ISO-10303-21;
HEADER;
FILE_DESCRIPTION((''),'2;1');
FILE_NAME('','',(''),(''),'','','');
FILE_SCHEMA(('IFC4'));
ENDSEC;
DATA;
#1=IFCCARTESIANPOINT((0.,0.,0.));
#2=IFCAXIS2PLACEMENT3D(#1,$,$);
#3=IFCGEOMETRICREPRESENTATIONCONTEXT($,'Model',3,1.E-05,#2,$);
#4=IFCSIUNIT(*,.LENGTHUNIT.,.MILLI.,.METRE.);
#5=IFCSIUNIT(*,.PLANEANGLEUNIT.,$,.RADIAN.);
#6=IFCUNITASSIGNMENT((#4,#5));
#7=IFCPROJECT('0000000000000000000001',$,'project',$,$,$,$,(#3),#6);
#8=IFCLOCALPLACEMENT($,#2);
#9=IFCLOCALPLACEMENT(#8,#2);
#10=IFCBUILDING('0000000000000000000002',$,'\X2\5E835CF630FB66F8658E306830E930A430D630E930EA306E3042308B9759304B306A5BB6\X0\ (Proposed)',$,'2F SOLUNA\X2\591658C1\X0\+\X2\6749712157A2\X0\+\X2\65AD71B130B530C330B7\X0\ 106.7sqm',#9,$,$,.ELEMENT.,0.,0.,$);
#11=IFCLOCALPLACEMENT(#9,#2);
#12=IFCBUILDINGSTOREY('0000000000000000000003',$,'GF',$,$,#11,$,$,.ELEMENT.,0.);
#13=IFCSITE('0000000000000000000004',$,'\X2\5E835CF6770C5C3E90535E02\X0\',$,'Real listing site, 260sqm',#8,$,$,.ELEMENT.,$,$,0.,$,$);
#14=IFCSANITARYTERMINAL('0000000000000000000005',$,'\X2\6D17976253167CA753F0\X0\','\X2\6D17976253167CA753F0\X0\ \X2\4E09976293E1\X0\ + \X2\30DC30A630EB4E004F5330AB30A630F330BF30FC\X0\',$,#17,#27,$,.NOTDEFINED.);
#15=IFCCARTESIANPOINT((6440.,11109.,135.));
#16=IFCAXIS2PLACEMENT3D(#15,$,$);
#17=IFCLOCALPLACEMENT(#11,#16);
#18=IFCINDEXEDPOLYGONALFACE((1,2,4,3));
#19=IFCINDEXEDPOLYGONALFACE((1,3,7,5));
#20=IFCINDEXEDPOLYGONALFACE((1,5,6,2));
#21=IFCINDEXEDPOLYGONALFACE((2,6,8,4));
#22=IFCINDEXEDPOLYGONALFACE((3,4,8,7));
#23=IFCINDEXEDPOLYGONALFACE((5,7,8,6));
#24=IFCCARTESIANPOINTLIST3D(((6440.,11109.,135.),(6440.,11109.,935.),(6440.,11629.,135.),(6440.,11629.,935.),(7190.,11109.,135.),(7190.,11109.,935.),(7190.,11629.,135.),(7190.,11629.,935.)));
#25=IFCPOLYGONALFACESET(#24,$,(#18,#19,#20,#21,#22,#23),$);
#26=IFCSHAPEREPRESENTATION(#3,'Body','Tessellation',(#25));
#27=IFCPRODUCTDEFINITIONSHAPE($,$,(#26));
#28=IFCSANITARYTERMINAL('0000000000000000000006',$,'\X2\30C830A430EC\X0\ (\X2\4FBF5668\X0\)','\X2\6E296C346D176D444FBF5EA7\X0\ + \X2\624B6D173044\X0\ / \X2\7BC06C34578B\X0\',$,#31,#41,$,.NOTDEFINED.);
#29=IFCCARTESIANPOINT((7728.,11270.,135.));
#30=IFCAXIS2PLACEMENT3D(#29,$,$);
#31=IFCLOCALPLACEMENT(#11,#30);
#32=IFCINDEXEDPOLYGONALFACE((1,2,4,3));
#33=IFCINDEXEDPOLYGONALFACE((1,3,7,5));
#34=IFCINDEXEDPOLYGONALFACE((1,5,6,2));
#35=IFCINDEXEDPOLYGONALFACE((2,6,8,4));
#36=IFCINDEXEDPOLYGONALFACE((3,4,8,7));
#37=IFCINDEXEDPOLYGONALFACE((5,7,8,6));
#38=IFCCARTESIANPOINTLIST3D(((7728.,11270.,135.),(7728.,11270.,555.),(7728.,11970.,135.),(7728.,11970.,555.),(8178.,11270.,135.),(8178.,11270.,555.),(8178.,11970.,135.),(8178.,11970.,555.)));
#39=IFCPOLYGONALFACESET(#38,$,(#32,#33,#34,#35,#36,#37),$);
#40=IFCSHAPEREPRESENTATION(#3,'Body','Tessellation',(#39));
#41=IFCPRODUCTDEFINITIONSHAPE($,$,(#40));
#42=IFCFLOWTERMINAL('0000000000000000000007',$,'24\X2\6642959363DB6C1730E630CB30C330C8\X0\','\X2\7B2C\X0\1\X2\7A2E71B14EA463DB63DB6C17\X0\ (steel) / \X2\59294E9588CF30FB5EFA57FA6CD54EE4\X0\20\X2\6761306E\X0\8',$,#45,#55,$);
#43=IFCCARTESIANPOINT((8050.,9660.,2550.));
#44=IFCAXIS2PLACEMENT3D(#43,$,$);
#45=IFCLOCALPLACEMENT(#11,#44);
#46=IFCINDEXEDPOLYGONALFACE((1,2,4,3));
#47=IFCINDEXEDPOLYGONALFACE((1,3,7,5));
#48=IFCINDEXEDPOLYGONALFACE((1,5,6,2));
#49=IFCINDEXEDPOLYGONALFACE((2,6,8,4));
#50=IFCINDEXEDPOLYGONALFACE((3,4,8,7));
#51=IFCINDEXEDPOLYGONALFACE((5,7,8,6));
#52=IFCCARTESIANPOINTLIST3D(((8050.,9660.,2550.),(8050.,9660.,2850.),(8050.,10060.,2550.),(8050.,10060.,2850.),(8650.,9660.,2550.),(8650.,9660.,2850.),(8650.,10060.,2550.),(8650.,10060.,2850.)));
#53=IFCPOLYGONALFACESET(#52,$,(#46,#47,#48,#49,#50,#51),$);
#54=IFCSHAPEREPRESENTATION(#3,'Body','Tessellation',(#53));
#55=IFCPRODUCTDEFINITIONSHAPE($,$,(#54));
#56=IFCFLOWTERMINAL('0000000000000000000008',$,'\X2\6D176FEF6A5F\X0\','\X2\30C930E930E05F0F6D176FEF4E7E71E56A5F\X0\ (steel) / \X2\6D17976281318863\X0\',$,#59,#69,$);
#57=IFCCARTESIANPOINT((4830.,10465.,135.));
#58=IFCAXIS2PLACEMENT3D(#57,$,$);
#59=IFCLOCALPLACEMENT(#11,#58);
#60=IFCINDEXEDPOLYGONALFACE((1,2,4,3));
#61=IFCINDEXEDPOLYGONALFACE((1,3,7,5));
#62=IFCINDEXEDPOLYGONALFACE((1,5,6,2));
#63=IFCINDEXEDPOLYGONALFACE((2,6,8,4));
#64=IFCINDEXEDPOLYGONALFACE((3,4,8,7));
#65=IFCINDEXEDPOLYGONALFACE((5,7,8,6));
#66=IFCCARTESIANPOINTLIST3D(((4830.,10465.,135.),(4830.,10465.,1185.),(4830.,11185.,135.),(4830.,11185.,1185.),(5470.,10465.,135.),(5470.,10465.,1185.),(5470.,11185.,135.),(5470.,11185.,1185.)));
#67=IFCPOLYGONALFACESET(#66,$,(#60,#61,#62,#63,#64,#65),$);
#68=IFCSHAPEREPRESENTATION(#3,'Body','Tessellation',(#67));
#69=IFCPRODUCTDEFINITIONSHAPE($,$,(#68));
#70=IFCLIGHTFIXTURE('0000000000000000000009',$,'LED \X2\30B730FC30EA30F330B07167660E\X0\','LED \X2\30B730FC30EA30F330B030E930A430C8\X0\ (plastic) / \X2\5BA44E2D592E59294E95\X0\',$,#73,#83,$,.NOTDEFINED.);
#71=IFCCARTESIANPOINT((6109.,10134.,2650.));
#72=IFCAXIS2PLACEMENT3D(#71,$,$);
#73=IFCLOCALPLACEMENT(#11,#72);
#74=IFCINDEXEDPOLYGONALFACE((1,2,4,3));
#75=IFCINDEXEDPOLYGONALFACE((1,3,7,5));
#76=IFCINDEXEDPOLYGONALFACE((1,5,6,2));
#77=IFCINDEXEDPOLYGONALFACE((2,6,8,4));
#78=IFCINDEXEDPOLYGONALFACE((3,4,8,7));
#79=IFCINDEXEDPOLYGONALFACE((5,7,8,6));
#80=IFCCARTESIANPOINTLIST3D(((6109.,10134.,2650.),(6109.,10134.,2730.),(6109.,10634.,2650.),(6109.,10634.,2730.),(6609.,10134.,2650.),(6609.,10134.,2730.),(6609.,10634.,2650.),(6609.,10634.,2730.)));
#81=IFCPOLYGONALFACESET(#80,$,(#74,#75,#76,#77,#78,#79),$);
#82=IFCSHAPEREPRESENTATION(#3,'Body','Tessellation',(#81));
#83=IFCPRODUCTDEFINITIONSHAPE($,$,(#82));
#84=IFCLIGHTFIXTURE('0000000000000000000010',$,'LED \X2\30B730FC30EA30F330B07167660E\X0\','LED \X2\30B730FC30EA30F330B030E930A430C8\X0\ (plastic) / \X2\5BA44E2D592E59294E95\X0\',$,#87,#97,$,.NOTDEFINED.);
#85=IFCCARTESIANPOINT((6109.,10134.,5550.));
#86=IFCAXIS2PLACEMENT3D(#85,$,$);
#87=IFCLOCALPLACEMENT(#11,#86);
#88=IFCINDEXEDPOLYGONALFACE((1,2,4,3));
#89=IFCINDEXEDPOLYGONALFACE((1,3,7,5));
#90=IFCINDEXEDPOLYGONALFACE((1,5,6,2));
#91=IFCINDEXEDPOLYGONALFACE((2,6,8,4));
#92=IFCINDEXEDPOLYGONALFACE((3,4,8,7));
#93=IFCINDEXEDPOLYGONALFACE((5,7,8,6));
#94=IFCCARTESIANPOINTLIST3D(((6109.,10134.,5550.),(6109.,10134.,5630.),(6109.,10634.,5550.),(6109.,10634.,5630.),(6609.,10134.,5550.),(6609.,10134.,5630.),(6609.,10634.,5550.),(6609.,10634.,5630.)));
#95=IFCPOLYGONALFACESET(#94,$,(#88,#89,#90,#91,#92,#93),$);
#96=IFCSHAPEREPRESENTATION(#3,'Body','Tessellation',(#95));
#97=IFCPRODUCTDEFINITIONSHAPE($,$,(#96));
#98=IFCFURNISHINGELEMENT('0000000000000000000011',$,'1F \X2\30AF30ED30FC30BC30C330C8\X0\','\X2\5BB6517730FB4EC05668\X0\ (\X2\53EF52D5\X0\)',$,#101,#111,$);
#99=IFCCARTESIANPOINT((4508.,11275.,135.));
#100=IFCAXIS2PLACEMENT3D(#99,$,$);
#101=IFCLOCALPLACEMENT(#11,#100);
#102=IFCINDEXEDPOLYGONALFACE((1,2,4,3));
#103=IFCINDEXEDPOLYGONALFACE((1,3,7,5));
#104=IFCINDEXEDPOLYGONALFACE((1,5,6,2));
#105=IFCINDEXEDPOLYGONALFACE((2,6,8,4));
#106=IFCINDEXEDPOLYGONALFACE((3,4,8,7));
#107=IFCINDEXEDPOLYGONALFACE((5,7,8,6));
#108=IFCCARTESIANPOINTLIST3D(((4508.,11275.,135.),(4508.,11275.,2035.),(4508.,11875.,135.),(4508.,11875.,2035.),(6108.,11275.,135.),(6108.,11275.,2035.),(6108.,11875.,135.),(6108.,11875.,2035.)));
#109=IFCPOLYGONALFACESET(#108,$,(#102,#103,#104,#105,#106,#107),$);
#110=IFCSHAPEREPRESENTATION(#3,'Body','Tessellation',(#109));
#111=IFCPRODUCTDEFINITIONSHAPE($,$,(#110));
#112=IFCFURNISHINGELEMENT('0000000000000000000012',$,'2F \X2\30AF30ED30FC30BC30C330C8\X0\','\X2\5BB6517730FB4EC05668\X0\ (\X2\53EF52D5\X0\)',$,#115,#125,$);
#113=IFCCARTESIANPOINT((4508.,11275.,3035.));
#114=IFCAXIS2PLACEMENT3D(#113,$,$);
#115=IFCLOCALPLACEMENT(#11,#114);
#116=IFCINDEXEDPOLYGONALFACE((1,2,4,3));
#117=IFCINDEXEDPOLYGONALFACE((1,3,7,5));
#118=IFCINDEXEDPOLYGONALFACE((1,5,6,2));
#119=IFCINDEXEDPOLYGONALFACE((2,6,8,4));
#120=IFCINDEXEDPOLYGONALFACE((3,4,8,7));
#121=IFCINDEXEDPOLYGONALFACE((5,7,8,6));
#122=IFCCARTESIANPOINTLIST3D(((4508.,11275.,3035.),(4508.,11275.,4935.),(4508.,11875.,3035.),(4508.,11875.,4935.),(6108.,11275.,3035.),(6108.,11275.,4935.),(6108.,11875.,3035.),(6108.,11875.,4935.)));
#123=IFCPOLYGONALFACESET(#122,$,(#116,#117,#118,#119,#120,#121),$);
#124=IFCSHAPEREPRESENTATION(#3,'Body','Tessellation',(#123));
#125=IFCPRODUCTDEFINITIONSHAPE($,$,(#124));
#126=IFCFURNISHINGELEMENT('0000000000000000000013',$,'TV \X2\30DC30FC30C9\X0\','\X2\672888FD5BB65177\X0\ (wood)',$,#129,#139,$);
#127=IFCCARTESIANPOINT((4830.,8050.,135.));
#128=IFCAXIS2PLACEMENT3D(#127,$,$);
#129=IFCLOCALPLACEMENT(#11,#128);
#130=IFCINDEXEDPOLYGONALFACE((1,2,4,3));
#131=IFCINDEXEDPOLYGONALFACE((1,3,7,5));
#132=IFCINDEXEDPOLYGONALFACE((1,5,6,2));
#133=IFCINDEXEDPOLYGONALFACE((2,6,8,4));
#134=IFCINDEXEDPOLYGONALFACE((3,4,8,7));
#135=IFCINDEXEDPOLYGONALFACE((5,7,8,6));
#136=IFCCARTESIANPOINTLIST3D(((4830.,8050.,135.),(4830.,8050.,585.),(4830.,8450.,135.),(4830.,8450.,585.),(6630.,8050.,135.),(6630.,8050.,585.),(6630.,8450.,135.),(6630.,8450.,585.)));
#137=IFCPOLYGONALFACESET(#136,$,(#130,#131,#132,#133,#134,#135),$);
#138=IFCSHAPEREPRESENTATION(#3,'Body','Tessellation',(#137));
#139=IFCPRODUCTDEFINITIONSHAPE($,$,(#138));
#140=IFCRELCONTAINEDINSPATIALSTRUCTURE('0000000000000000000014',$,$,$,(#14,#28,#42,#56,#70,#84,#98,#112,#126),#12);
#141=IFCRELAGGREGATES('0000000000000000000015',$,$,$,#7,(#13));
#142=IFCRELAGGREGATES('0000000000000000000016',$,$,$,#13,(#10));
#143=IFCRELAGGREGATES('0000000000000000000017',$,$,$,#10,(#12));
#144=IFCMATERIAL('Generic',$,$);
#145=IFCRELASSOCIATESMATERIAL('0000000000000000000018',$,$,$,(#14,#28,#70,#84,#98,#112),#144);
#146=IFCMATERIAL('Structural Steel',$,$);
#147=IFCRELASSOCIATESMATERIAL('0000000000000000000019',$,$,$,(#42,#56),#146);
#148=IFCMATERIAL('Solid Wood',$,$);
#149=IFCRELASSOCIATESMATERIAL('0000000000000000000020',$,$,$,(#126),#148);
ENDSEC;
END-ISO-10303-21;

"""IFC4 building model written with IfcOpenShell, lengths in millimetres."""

from ifc_helpers import new_model, si_unit, frame, frame_2d, origin, place, context, project, spatial, rectangle, extrude, material, element, save


model = new_model("IFC4")

# Units and contexts
model_context = context("Model", 3, precision=1e-05, world=origin())
ifc_project = project(units=[si_unit("LENGTHUNIT", "METRE", prefix="MILLI"), si_unit("PLANEANGLEUNIT", "RADIAN")], contexts=[model_context])

# Site, building, storey
site_placement = place(None, origin())
site = spatial("IfcSite", under=ifc_project, at=site_placement, Name="広島県尾道市", ObjectType="Real listing site, 260sqm", CompositionType="ELEMENT", RefElevation=0.0)
building_placement = place(site_placement, origin())
building = spatial("IfcBuilding", under=site, at=building_placement, Name="広島・書斎とライブラリのある静かな家 (Proposed)", ObjectType="2F SOLUNA外壁+杉無垢+断熱サッシ 106.7sqm", CompositionType="ELEMENT", ElevationOfRefHeight=0.0, ElevationOfTerrain=0.0)
storey_placement = place(building_placement, origin())
storey = spatial("IfcBuildingStorey", under=building, at=storey_placement, Name="GF", CompositionType="ELEMENT", Elevation=0.0)

# Shared definitions
ifc_material_1 = material(Name="Solid Wood")

# Sanitary terminals
ifc_material_2 = material(Name="Generic")
sanitary_terminal_1_placement = place(storey_placement, frame((6440.0, 11109.0, 135.0)))
element("IfcSanitaryTerminal", 1, at=sanitary_terminal_1_placement, inside=storey, material=ifc_material_2, Name="洗面化粧台", Description="洗面化粧台 三面鏡 + ボウル一体カウンター", PredefinedType="NOTDEFINED", context=model_context, shape_type="SweptSolid", body=[
    extrude(rectangle(XDim=750.0, YDim=520.0, at=frame_2d((375.0, 260.0))), frame((6440.0, 11109.0, 135.0)), (0.0, 0.0, 1.0), 800.0),
])
sanitary_terminal_2_placement = place(storey_placement, frame((7728.0, 11270.0, 135.0)))
element("IfcSanitaryTerminal", 2, at=sanitary_terminal_2_placement, inside=storey, material=ifc_material_2, Name="トイレ (便器)", Description="温水洗浄便座 + 手洗い / 節水型", PredefinedType="NOTDEFINED", context=model_context, shape_type="SweptSolid", body=[
    extrude(rectangle(XDim=450.0, YDim=700.0, at=frame_2d((225.0, 350.0))), frame((7728.0, 11270.0, 135.0)), (0.0, 0.0, 1.0), 420.0),
])

# Flow terminals
ifc_material_3 = material(Name="Structural Steel")
flow_terminal_1_placement = place(storey_placement, frame((8050.0, 9660.0, 2550.0)))
element("IfcFlowTerminal", 3, at=flow_terminal_1_placement, inside=storey, material=ifc_material_3, Name="24時間換気ユニット", Description="第1種熱交換換気 (steel) / 天井裏・建基法令20条の8", context=model_context, shape_type="SweptSolid", body=[
    extrude(rectangle(XDim=600.0, YDim=400.0, at=frame_2d((300.0, 200.0))), frame((8050.0, 9660.0, 2550.0)), (0.0, 0.0, 1.0), 300.0),
])
flow_terminal_2_placement = place(storey_placement, frame((4830.0, 10465.0, 135.0)))
element("IfcFlowTerminal", 4, at=flow_terminal_2_placement, inside=storey, material=ifc_material_3, Name="洗濯機", Description="ドラム式洗濯乾燥機 (steel) / 洗面脱衣", context=model_context, shape_type="SweptSolid", body=[
    extrude(rectangle(XDim=640.0, YDim=720.0, at=frame_2d((320.0, 360.0))), frame((4830.0, 10465.0, 135.0)), (0.0, 0.0, 1.0), 1050.0),
])

# Light fixtures
light_fixture_1_placement = place(storey_placement, frame((6109.0, 10134.0, 2650.0)))
element("IfcLightFixture", 5, at=light_fixture_1_placement, inside=storey, material=ifc_material_2, Name="LED シーリング照明", Description="LED シーリングライト (plastic) / 室中央天井", PredefinedType="NOTDEFINED", context=model_context, shape_type="SweptSolid", body=[
    extrude(rectangle(XDim=500.0, YDim=500.0, at=frame_2d((250.0, 250.0))), frame((6109.0, 10134.0, 2650.0)), (0.0, 0.0, 1.0), 80.0),
])
light_fixture_2_placement = place(storey_placement, frame((6109.0, 10134.0, 5550.0)))
element("IfcLightFixture", 6, at=light_fixture_2_placement, inside=storey, material=ifc_material_2, Name="LED シーリング照明", Description="LED シーリングライト (plastic) / 室中央天井", PredefinedType="NOTDEFINED", context=model_context, shape_type="SweptSolid", body=[
    extrude(rectangle(XDim=500.0, YDim=500.0, at=frame_2d((250.0, 250.0))), frame((6109.0, 10134.0, 5550.0)), (0.0, 0.0, 1.0), 80.0),
])

# Furnishing elements
furnishing_1_placement = place(storey_placement, frame((4508.0, 11275.0, 135.0)))
element("IfcFurnishingElement", 7, at=furnishing_1_placement, inside=storey, material=ifc_material_2, Name="1F クローゼット", Description="家具・什器 (可動)", context=model_context, shape_type="SweptSolid", body=[
    extrude(rectangle(XDim=1600.0, YDim=600.0, at=frame_2d((800.0, 300.0))), frame((4508.0, 11275.0, 135.0)), (0.0, 0.0, 1.0), 1900.0),
])
furnishing_2_placement = place(storey_placement, frame((4508.0, 11275.0, 3035.0)))
element("IfcFurnishingElement", 8, at=furnishing_2_placement, inside=storey, material=ifc_material_2, Name="2F クローゼット", Description="家具・什器 (可動)", context=model_context, shape_type="SweptSolid", body=[
    extrude(rectangle(XDim=1600.0, YDim=600.0, at=frame_2d((800.0, 300.0))), frame((4508.0, 11275.0, 3035.0)), (0.0, 0.0, 1.0), 1900.0),
])
furnishing_3_placement = place(storey_placement, frame((4830.0, 8050.0, 135.0)))
element("IfcFurnishingElement", 9, at=furnishing_3_placement, inside=storey, material=ifc_material_1, Name="TV ボード", Description="木製家具 (wood)", context=model_context, shape_type="SweptSolid", body=[
    extrude(rectangle(XDim=1800.0, YDim=400.0, at=frame_2d((900.0, 200.0))), frame((4830.0, 8050.0, 135.0)), (0.0, 0.0, 1.0), 450.0),
])

save(model, "model.ifc")
